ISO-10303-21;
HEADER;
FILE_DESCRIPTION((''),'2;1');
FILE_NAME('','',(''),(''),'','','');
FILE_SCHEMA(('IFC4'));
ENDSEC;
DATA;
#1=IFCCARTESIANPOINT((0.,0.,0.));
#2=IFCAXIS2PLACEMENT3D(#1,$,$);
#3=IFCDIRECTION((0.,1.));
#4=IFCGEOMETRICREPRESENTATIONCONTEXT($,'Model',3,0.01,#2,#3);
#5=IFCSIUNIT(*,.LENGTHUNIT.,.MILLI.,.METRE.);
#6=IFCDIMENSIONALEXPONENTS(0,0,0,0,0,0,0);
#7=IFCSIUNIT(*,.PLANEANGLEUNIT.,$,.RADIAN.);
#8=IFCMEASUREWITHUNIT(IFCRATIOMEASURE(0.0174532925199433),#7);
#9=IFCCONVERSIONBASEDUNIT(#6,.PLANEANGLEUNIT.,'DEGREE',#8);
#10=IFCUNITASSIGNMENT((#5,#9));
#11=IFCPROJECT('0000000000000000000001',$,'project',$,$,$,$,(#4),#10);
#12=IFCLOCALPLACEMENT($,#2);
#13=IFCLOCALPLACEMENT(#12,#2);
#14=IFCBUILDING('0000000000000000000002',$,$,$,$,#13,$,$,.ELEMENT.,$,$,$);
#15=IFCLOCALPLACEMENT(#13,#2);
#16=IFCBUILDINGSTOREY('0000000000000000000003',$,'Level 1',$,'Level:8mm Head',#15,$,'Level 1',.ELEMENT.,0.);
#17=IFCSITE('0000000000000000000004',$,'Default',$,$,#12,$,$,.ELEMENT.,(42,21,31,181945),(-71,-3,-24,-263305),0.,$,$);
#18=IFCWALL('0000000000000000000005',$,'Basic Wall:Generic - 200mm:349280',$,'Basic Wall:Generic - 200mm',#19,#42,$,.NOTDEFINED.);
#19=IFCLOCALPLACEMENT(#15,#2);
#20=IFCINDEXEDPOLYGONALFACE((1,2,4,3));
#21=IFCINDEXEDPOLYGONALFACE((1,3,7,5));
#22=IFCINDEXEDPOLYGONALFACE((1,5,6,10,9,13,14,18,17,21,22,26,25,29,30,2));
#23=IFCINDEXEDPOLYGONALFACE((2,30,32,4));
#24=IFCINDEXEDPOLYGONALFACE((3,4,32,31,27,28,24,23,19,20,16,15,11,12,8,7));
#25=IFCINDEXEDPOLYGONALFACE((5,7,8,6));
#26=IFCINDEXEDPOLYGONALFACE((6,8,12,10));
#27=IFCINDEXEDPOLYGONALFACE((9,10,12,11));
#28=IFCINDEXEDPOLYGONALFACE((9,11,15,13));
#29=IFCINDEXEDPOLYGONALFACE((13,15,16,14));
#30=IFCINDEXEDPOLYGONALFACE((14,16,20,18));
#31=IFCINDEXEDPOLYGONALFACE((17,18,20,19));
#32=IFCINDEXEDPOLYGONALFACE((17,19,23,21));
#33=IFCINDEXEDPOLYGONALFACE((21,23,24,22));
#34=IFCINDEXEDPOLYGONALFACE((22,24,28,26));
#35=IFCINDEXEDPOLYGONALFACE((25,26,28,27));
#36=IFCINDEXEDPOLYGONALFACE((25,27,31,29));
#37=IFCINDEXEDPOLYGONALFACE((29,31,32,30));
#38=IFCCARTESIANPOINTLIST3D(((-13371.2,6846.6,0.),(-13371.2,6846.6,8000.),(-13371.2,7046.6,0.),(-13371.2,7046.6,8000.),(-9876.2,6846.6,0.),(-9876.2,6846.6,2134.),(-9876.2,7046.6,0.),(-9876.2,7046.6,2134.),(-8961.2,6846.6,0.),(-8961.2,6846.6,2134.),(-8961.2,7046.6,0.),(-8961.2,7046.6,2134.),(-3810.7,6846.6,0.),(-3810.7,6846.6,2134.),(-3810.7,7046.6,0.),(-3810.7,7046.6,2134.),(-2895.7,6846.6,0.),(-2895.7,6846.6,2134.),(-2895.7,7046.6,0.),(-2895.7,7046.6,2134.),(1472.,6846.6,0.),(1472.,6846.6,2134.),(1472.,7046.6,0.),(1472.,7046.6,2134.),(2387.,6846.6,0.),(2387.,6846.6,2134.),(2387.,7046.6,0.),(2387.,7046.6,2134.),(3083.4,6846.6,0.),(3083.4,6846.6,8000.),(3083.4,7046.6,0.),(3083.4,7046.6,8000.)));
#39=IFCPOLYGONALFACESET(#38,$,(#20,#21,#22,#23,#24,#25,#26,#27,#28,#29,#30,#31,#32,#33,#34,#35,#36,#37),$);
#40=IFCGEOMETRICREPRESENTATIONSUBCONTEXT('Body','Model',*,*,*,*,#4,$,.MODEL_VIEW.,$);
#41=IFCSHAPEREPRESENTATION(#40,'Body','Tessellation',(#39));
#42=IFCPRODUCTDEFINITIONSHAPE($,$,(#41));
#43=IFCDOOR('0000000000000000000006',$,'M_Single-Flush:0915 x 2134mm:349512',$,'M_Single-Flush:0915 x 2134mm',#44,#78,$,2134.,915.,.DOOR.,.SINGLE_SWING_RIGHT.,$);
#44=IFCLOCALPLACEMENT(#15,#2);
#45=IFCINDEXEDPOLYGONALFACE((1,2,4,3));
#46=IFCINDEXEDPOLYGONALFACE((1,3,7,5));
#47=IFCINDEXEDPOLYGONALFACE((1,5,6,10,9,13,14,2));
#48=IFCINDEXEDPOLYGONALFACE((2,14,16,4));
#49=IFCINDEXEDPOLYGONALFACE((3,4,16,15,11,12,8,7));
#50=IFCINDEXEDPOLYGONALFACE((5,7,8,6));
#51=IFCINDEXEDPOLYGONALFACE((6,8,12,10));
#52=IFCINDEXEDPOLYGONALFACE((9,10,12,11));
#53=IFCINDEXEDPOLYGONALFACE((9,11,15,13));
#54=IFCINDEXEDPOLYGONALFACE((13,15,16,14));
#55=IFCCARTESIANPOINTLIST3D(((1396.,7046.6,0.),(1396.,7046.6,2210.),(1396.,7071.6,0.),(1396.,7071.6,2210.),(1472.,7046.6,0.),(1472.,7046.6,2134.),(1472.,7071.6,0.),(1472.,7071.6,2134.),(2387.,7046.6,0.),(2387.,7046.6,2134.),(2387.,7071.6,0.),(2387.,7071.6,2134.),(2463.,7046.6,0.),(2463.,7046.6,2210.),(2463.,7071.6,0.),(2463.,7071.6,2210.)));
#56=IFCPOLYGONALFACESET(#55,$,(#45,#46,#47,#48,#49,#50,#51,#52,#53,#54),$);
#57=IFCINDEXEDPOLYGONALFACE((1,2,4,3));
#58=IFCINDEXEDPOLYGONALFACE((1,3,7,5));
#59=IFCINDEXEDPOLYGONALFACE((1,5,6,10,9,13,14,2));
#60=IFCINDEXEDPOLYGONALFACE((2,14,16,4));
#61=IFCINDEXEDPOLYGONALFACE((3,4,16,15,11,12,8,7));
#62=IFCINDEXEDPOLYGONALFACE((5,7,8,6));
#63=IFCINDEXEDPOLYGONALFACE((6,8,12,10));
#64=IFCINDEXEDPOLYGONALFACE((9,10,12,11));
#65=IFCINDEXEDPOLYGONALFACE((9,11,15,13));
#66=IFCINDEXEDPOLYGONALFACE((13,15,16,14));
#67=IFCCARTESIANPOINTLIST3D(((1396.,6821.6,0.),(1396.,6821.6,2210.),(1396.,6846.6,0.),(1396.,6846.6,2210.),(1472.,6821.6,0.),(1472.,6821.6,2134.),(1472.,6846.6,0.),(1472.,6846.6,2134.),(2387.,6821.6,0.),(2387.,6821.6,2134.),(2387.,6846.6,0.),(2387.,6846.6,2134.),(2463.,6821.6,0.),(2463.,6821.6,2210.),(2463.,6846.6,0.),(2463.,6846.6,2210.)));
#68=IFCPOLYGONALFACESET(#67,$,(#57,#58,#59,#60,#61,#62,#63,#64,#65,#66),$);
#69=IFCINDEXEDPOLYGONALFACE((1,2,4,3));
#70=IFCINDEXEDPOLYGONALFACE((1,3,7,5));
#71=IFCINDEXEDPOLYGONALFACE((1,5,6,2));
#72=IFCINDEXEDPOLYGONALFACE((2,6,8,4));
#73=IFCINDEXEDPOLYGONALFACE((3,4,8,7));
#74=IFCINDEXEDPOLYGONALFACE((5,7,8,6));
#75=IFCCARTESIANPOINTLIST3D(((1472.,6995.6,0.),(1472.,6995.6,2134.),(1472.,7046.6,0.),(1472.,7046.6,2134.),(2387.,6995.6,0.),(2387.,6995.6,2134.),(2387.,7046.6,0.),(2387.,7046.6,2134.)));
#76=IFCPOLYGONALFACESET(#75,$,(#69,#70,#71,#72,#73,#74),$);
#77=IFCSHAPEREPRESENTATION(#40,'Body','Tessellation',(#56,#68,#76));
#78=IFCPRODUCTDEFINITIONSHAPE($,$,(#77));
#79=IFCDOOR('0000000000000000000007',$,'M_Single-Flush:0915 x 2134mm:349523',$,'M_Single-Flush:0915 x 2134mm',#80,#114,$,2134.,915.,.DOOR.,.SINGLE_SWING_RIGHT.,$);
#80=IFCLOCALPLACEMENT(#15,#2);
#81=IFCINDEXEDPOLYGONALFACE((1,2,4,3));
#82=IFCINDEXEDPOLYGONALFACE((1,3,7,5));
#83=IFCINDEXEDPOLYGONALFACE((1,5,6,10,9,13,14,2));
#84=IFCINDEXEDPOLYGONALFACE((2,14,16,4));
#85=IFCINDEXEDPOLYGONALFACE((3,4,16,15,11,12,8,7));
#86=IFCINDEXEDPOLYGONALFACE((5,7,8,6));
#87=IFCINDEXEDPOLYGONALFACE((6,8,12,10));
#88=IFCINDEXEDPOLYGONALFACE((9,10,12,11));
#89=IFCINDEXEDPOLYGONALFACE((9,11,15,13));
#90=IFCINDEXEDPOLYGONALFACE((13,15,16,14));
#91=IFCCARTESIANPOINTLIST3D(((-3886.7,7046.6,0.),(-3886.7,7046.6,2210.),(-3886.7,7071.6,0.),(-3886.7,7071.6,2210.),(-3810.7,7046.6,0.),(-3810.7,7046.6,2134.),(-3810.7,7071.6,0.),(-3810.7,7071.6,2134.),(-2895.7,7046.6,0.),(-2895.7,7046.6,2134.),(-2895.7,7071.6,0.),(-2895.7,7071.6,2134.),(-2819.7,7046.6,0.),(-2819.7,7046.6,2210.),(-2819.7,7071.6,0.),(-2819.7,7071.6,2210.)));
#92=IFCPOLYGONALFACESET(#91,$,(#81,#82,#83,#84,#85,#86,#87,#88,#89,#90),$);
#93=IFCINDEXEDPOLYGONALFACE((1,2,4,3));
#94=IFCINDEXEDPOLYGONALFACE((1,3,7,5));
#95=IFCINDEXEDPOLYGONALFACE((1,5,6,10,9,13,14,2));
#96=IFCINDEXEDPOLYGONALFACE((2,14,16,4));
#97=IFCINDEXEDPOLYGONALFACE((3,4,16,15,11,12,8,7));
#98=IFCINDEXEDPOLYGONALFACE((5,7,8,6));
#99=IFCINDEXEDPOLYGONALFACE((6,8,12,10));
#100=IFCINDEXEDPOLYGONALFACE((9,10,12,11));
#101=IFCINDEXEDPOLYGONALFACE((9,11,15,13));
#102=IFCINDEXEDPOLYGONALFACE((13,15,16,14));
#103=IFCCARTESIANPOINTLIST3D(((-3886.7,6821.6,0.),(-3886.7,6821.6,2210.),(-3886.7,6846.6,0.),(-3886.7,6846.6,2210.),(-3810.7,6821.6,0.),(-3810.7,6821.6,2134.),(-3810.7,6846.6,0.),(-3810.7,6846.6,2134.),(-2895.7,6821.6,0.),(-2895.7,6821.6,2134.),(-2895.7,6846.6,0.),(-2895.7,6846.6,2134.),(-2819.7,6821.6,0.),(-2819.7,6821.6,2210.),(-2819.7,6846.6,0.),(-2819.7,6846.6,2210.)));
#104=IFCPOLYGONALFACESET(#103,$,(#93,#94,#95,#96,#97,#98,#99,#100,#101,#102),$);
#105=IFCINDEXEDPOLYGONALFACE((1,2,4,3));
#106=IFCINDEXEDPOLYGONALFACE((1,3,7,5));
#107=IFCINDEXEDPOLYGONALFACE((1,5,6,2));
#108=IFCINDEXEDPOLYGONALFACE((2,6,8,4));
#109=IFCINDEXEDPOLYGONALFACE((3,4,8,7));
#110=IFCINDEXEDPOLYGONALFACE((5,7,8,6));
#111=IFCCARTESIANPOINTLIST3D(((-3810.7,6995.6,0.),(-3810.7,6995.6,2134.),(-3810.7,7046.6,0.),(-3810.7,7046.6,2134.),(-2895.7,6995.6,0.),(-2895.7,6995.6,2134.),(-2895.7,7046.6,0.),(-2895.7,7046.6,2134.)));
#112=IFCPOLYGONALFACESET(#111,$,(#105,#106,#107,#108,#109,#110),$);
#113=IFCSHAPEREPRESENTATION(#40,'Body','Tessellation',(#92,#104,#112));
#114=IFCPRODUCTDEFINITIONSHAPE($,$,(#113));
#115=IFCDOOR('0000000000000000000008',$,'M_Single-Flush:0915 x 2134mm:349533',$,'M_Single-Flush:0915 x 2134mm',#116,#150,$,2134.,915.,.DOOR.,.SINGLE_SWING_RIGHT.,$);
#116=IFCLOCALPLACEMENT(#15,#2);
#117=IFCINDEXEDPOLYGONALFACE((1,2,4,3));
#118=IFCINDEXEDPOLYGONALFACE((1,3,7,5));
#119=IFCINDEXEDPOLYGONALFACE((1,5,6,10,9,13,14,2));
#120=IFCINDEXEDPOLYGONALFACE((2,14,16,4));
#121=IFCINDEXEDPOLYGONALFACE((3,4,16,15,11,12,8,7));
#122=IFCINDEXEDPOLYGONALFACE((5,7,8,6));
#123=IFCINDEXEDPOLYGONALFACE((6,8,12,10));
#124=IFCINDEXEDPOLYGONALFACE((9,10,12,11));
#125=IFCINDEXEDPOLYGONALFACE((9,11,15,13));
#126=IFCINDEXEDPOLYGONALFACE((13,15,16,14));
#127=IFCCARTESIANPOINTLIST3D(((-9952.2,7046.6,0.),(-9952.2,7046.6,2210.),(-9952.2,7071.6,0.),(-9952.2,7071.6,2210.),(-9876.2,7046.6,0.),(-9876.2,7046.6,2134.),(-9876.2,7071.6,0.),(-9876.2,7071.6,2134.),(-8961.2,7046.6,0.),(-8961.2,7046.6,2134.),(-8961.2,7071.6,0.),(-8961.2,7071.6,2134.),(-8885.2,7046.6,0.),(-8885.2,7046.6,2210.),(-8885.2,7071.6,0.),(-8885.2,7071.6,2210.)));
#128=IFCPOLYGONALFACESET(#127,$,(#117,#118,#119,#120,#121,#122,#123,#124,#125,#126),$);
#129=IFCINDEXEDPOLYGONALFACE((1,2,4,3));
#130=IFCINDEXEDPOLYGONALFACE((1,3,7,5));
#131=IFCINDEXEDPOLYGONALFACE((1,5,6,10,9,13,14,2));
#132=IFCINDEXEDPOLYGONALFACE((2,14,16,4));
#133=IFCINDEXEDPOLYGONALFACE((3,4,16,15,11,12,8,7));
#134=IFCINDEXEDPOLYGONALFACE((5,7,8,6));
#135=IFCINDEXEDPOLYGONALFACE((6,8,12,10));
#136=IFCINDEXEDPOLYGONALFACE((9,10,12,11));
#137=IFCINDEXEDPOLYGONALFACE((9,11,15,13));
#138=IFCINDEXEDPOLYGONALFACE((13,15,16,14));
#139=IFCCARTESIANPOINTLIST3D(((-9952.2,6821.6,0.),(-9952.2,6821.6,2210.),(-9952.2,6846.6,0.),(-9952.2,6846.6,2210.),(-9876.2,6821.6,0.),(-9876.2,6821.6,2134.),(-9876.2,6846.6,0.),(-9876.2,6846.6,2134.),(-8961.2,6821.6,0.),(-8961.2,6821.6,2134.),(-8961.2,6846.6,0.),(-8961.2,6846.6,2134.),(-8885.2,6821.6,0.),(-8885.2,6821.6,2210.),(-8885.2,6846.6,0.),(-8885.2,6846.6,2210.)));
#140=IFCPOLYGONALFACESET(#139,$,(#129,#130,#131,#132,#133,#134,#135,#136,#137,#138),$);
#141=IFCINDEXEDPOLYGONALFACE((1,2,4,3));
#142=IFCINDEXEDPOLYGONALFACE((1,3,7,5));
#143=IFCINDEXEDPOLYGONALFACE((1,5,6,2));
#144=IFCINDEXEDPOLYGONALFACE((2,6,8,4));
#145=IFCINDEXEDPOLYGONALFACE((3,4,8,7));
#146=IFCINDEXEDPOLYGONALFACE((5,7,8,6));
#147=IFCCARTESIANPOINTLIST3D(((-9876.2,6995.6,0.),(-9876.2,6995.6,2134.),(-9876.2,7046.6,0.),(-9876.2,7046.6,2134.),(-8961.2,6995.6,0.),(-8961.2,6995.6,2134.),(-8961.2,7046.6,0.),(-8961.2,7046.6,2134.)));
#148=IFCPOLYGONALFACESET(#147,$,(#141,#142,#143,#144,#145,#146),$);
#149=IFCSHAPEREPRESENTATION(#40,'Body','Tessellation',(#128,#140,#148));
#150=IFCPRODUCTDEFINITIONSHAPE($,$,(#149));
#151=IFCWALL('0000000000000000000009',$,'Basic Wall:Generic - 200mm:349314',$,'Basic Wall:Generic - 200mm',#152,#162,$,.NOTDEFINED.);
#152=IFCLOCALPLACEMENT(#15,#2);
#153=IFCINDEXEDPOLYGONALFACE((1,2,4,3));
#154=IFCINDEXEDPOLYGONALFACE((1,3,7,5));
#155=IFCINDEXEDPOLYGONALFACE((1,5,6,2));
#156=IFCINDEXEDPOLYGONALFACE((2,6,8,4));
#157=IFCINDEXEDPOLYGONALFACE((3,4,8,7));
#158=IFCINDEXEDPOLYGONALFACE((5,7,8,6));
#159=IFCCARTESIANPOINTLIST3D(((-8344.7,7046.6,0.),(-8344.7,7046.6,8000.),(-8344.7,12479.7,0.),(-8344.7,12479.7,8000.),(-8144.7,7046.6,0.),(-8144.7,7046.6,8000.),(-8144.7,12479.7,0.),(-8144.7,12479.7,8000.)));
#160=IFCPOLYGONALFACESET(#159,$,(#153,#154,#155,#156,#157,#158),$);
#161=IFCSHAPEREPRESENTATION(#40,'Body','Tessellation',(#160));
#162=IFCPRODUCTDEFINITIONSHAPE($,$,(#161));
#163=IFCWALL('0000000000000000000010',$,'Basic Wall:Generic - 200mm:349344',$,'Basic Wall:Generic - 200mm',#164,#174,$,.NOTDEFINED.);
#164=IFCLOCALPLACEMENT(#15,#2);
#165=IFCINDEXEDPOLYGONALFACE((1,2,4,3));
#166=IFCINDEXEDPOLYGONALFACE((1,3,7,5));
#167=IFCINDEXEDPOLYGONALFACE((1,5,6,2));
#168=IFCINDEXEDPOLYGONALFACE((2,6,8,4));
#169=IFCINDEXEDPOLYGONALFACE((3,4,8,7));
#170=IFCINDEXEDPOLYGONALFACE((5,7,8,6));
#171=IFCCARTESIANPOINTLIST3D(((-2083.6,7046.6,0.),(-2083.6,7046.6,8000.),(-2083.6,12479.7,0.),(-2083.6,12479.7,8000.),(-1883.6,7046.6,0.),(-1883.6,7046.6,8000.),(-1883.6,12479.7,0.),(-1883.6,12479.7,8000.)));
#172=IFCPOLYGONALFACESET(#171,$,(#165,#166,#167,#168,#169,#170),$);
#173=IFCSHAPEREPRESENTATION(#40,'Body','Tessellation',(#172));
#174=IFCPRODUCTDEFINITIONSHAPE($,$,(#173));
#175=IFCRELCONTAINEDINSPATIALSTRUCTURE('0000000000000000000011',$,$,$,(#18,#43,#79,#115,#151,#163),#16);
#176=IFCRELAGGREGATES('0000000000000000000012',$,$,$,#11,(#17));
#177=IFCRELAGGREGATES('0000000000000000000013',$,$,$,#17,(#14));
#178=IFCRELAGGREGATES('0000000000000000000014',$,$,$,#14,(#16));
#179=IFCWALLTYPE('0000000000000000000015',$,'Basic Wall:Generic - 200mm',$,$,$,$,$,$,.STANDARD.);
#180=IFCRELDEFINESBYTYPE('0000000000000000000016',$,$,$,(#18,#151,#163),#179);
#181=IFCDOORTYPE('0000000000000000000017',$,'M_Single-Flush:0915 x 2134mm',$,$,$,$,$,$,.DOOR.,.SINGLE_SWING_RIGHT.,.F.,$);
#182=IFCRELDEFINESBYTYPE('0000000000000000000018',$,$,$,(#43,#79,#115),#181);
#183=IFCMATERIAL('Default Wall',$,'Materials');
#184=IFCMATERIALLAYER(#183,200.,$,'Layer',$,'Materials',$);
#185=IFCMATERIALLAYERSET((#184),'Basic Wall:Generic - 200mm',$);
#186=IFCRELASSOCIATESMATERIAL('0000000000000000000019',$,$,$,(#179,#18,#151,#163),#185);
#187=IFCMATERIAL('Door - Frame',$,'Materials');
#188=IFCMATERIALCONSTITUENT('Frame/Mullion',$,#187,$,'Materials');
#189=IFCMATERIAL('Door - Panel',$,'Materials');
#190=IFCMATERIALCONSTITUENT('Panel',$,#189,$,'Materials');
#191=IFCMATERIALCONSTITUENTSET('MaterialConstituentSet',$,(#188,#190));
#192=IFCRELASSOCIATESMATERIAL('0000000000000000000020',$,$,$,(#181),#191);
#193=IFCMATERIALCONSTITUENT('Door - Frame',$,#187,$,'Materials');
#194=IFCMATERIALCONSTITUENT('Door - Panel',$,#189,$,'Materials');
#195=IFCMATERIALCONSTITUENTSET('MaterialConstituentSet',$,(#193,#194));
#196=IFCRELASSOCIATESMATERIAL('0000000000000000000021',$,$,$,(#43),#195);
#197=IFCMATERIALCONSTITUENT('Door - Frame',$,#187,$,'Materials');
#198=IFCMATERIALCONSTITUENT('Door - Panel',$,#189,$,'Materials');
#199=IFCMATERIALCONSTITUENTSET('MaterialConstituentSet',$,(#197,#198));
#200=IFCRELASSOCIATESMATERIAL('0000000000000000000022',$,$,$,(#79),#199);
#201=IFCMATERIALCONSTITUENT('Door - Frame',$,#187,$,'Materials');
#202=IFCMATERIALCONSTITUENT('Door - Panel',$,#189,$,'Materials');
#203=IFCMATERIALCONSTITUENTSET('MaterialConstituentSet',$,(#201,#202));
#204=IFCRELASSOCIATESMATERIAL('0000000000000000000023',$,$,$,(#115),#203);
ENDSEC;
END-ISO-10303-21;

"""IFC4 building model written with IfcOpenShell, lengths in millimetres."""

from ifc_helpers import new_model, entity, si_unit, converted_unit, direction, frame, frame_2d, origin, place, context, subcontext, project, spatial, polyline, rectangle, outline, extrude, source, transform, mapped, material, layer, layer_set, layer_usage, constituent, constituent_set, type_object, type_shapes, element, fill, save


model = new_model("IFC4")

# Units and contexts
model_context = context("Model", 3, precision=0.01, world=origin(), true_north=direction((0.0, 1.0)))
body_context = subcontext(model_context, "Body", "Model", "MODEL_VIEW")
ifc_project = project(units=[si_unit("LENGTHUNIT", "METRE", prefix="MILLI"), converted_unit("PLANEANGLEUNIT", "DEGREE", entity("IfcRatioMeasure", 0.0174532925199433), si_unit("PLANEANGLEUNIT", "RADIAN"), dimensions=[0, 0, 0, 0, 0, 0, 0])], contexts=[model_context])

# Site, building, storey
site_placement = place(None, origin())
site = spatial("IfcSite", under=ifc_project, at=site_placement, Name="Default", CompositionType="ELEMENT", RefLatitude=(42, 21, 31, 181945), RefLongitude=(-71, -3, -24, -263305), RefElevation=0.0)
building_placement = place(site_placement, origin())
building = spatial("IfcBuilding", under=site, at=building_placement, CompositionType="ELEMENT")
storey_placement = place(building_placement, origin())
storey = spatial("IfcBuildingStorey", under=building, at=storey_placement, Name="Level 1", ObjectType="Level:8mm Head", LongName="Level 1", CompositionType="ELEMENT", Elevation=0.0)

# Shared definitions
ifc_material_1 = material(Name="Default Wall", Category="Materials")
ifc_layer = layer(ifc_material_1, 200.0, Name="Layer", Category="Materials")
ifc_layer_set = layer_set([ifc_layer], Name="Basic Wall:Generic - 200mm")
wall_type = type_object("IfcWallType", Name="Basic Wall:Generic - 200mm", PredefinedType="STANDARD", material=ifc_layer_set)

# Shared definitions
ifc_material_2 = material(Name="Door - Frame", Category="Materials")
ifc_material_3 = material(Name="Door - Panel", Category="Materials")

# Shared definitions
ifc_constituent_1 = constituent(ifc_material_2, Name="Frame/Mullion", Category="Materials")
ifc_constituent_2 = constituent(ifc_material_3, Name="Panel", Category="Materials")
ifc_constituent_set_1 = constituent_set(constituents=[ifc_constituent_1, ifc_constituent_2], Name="MaterialConstituentSet")
door_type_1 = type_object("IfcDoorType", Name="M_Single-Flush:0915 x 2134mm", OperationType="SINGLE_SWING_RIGHT", ParameterTakesPrecedence=False, PredefinedType="DOOR", material=ifc_constituent_set_1)
shared_shape_1 = source(origin(), body_context, "Body", "SweptSolid", [
    extrude(outline(polyline([(-533.5, -1124.0), (533.5, -1124.0), (533.5, 1086.0), (457.5, 1086.0), (457.5, -1048.0), (-457.5, -1048.0), (-457.5, 1086.0), (-533.5, 1086.0), (-533.5, -1124.0)])), frame((457.5, 200.0, 1086.0), z_axis=(0.0, 1.0, 0.0), x_axis=(1.0, 0.0, 0.0)), (0.0, 0.0, 1.0), 25.0),
    extrude(outline(polyline([(-1124.0, -533.5), (1086.0, -533.5), (1086.0, -457.5), (-1048.0, -457.5), (-1048.0, 457.5), (1086.0, 457.5), (1086.0, 533.5), (-1124.0, 533.5), (-1124.0, -533.5)])), frame((457.5, -25.0, 1086.0), z_axis=(0.0, 1.0, 0.0), x_axis=(0.0, 0.0, -1.0)), (0.0, 0.0, 1.0), 25.0),
    extrude(rectangle(XDim=51.0, YDim=915.0, at=frame_2d((0.0, 0.0), x_axis=(1.0, 0.0))), frame((457.5, 174.5, 0.0), z_axis=(0.0, 0.0, 1.0), x_axis=(0.0, 1.0, 0.0)), (0.0, 0.0, 1.0), 2134.0),
])
type_shapes(door_type_1, [shared_shape_1])

# Wall, openings, doors
ifc_layer_usage_1 = layer_usage(ifc_layer_set, "AXIS2", "POSITIVE", -100.0)
wall_1_placement = place(storey_placement, frame((-13371.2, 6946.6, 0.0)))
wall_1 = element("IfcWall", 1, at=wall_1_placement, inside=storey, type_object=wall_type, material=ifc_layer_usage_1, Name="Basic Wall:Generic - 200mm:349280", ObjectType="Basic Wall:Generic - 200mm", PredefinedType="NOTDEFINED", context=body_context, shape_type="SweptSolid", body=[
    extrude(rectangle(XDim=16454.6, YDim=200.0, at=frame_2d((8227.3, 0.0), x_axis=(-1.0, 0.0))), origin(), (0.0, 0.0, 1.0), 8000.0),
])
opening_1_placement = place(wall_1_placement, frame((14843.2, -100.0, 0.0)))
opening_1 = element("IfcOpeningElement", 2, at=opening_1_placement, cuts=wall_1, PredefinedType="OPENING", context=body_context, shape_type="SweptSolid", body=[
    extrude(rectangle(XDim=915.0, YDim=2134.0, at=frame_2d((1067.0, 457.5), x_axis=(0.0, 1.0))), frame((0.0, 0.0, 0.0), z_axis=(0.0, 1.0, 0.0), x_axis=(0.0, 0.0, 1.0)), (0.0, 0.0, 1.0), 200.0),
])
opening_2_placement = place(wall_1_placement, frame((9560.4, -100.0, 0.0)))
opening_2 = element("IfcOpeningElement", 3, at=opening_2_placement, cuts=wall_1, PredefinedType="OPENING", context=body_context, shape_type="SweptSolid", body=[
    extrude(rectangle(XDim=915.0, YDim=2134.0, at=frame_2d((1067.0, 457.5), x_axis=(0.0, 1.0))), frame((0.0, 0.0, 0.0), z_axis=(0.0, 1.0, 0.0), x_axis=(0.0, 0.0, 1.0)), (0.0, 0.0, 1.0), 200.0),
])
opening_3_placement = place(wall_1_placement, frame((3495.0, -100.0, 0.0)))
opening_3 = element("IfcOpeningElement", 4, at=opening_3_placement, cuts=wall_1, PredefinedType="OPENING", context=body_context, shape_type="SweptSolid", body=[
    extrude(rectangle(XDim=915.0, YDim=2134.0, at=frame_2d((1067.0, 457.5), x_axis=(0.0, 1.0))), frame((0.0, 0.0, 0.0), z_axis=(0.0, 1.0, 0.0), x_axis=(0.0, 0.0, 1.0)), (0.0, 0.0, 1.0), 200.0),
])
ifc_constituent_3 = constituent(ifc_material_2, Name="Door - Frame", Category="Materials")
ifc_constituent_4 = constituent(ifc_material_3, Name="Door - Panel", Category="Materials")
ifc_constituent_set_2 = constituent_set(constituents=[ifc_constituent_3, ifc_constituent_4], Name="MaterialConstituentSet")
door_1_placement = place(opening_1_placement, origin())
door_1 = element("IfcDoor", 5, at=door_1_placement, inside=storey, type_object=door_type_1, material=ifc_constituent_set_2, Name="M_Single-Flush:0915 x 2134mm:349512", ObjectType="M_Single-Flush:0915 x 2134mm", OperationType="SINGLE_SWING_RIGHT", OverallHeight=2134.0, OverallWidth=915.0, PredefinedType="DOOR", context=body_context, shape_type="MappedRepresentation", body=[
    mapped(shared_shape_1, transform((0.0, 0.0, 0.0), scale=1.0)),
])
fill(opening_1, door_1)
ifc_constituent_5 = constituent(ifc_material_2, Name="Door - Frame", Category="Materials")
ifc_constituent_6 = constituent(ifc_material_3, Name="Door - Panel", Category="Materials")
ifc_constituent_set_3 = constituent_set(constituents=[ifc_constituent_5, ifc_constituent_6], Name="MaterialConstituentSet")
door_2_placement = place(opening_2_placement, origin())
door_2 = element("IfcDoor", 6, at=door_2_placement, inside=storey, type_object=door_type_1, material=ifc_constituent_set_3, Name="M_Single-Flush:0915 x 2134mm:349523", ObjectType="M_Single-Flush:0915 x 2134mm", OperationType="SINGLE_SWING_RIGHT", OverallHeight=2134.0, OverallWidth=915.0, PredefinedType="DOOR", context=body_context, shape_type="MappedRepresentation", body=[
    mapped(shared_shape_1, transform((0.0, 0.0, 0.0), scale=1.0)),
])
fill(opening_2, door_2)
ifc_constituent_7 = constituent(ifc_material_2, Name="Door - Frame", Category="Materials")
ifc_constituent_8 = constituent(ifc_material_3, Name="Door - Panel", Category="Materials")
ifc_constituent_set_4 = constituent_set(constituents=[ifc_constituent_7, ifc_constituent_8], Name="MaterialConstituentSet")
door_3_placement = place(opening_3_placement, origin())
door_3 = element("IfcDoor", 7, at=door_3_placement, inside=storey, type_object=door_type_1, material=ifc_constituent_set_4, Name="M_Single-Flush:0915 x 2134mm:349533", ObjectType="M_Single-Flush:0915 x 2134mm", OperationType="SINGLE_SWING_RIGHT", OverallHeight=2134.0, OverallWidth=915.0, PredefinedType="DOOR", context=body_context, shape_type="MappedRepresentation", body=[
    mapped(shared_shape_1, transform((0.0, 0.0, 0.0), scale=1.0)),
])
fill(opening_3, door_3)

# Walls
ifc_layer_usage_2 = layer_usage(ifc_layer_set, "AXIS2", "NEGATIVE", 100.0)
wall_2_placement = place(storey_placement, frame((-8244.7, 7046.6, 0.0), z_axis=(0.0, 0.0, 1.0), x_axis=(0.0, 1.0, 0.0)))
element("IfcWall", 8, at=wall_2_placement, inside=storey, type_object=wall_type, material=ifc_layer_usage_2, Name="Basic Wall:Generic - 200mm:349314", ObjectType="Basic Wall:Generic - 200mm", PredefinedType="NOTDEFINED", context=body_context, shape_type="SweptSolid", body=[
    extrude(rectangle(XDim=5433.1, YDim=200.0, at=frame_2d((2716.6, 0.0), x_axis=(-1.0, 0.0))), origin(), (0.0, 0.0, 1.0), 8000.0),
])
ifc_layer_usage_3 = layer_usage(ifc_layer_set, "AXIS2", "NEGATIVE", 100.0)
wall_3_placement = place(storey_placement, frame((-1983.6, 7046.6, 0.0), z_axis=(0.0, 0.0, 1.0), x_axis=(0.0, 1.0, 0.0)))
element("IfcWall", 9, at=wall_3_placement, inside=storey, type_object=wall_type, material=ifc_layer_usage_3, Name="Basic Wall:Generic - 200mm:349344", ObjectType="Basic Wall:Generic - 200mm", PredefinedType="NOTDEFINED", context=body_context, shape_type="SweptSolid", body=[
    extrude(rectangle(XDim=5433.1, YDim=200.0, at=frame_2d((2716.6, 0.0), x_axis=(-1.0, 0.0))), origin(), (0.0, 0.0, 1.0), 8000.0),
])

save(model, "model.ifc")
